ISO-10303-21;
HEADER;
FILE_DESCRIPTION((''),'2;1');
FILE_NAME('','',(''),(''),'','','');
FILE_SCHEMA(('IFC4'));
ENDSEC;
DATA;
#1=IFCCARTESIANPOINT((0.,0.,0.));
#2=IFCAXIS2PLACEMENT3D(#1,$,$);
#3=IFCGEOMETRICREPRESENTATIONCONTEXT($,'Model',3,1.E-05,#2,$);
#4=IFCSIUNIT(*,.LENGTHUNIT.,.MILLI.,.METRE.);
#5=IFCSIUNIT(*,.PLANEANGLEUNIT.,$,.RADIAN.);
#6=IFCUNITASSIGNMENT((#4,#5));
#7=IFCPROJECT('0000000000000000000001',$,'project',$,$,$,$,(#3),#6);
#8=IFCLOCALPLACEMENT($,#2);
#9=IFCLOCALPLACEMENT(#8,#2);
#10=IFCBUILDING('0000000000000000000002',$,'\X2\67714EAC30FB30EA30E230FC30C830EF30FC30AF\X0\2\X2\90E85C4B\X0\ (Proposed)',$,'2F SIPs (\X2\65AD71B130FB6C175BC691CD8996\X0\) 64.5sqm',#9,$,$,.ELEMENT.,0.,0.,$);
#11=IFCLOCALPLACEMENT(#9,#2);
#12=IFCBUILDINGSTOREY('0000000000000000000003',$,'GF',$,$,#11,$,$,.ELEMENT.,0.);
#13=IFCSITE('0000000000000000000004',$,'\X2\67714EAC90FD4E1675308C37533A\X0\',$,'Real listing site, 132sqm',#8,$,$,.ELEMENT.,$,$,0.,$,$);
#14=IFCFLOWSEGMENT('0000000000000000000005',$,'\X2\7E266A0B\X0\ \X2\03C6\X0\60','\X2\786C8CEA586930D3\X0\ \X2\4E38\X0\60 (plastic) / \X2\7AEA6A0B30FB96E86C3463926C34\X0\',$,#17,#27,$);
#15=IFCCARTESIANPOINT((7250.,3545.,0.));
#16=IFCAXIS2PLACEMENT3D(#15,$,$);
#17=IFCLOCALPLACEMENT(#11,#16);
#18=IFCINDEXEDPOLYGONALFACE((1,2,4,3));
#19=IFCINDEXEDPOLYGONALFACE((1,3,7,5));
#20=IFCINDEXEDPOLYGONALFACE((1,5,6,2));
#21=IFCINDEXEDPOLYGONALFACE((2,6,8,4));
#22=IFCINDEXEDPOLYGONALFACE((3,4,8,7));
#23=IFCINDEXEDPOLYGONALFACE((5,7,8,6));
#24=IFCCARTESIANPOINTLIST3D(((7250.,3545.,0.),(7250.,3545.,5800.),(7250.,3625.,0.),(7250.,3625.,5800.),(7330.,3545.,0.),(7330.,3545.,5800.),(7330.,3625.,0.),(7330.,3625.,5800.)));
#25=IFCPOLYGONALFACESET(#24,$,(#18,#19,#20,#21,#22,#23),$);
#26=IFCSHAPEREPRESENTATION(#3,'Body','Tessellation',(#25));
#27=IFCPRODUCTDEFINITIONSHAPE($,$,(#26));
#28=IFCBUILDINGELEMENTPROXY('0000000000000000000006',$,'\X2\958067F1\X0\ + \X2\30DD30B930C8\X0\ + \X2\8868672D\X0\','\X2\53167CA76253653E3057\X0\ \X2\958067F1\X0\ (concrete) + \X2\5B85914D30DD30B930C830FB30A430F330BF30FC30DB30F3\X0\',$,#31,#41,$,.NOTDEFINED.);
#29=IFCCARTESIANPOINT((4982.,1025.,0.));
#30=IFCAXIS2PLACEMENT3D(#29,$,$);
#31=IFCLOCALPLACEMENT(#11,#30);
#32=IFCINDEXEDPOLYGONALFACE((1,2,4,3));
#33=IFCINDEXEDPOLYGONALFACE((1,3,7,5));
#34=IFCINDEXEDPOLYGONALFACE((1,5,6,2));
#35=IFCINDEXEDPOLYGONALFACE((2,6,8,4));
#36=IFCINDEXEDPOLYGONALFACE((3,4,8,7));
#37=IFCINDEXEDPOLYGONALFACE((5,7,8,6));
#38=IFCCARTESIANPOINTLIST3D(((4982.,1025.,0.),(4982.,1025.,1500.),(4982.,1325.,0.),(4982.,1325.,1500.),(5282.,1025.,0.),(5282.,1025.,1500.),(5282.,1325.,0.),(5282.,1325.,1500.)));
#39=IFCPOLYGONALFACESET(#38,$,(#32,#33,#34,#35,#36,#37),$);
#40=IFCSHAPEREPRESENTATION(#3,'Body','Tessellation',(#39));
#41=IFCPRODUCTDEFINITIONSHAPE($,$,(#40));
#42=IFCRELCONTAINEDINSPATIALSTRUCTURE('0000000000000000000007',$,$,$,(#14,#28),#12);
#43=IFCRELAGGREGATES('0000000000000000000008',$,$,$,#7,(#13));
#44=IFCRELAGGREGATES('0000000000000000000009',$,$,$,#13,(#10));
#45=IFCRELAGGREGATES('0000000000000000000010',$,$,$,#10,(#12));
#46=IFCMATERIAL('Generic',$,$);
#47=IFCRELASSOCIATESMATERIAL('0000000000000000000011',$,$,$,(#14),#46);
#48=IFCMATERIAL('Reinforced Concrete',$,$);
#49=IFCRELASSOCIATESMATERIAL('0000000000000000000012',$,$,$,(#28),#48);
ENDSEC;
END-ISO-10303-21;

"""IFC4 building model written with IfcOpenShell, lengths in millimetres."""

from ifc_helpers import new_model, si_unit, frame, frame_2d, origin, place, context, project, spatial, rectangle, extrude, material, element, save


model = new_model("IFC4")

# Units and contexts
model_context = context("Model", 3, precision=1e-05, world=origin())
ifc_project = project(units=[si_unit("LENGTHUNIT", "METRE", prefix="MILLI"), si_unit("PLANEANGLEUNIT", "RADIAN")], contexts=[model_context])

# Site, building, storey
site_placement = place(None, origin())
site = spatial("IfcSite", under=ifc_project, at=site_placement, Name="東京都世田谷区", ObjectType="Real listing site, 132sqm", CompositionType="ELEMENT", RefElevation=0.0)
building_placement = place(site_placement, origin())
building = spatial("IfcBuilding", under=site, at=building_placement, Name="東京・リモートワーク2部屋 (Proposed)", ObjectType="2F SIPs (断熱・気密重視) 64.5sqm", CompositionType="ELEMENT", ElevationOfRefHeight=0.0, ElevationOfTerrain=0.0)
storey_placement = place(building_placement, origin())
storey = spatial("IfcBuildingStorey", under=building, at=storey_placement, Name="GF", CompositionType="ELEMENT", Elevation=0.0)

# Shared definitions
ifc_material_1 = material(Name="Reinforced Concrete")

# Flow segment
ifc_material_2 = material(Name="Generic")
flow_segment_1_placement = place(storey_placement, frame((7250.0, 3545.0, 0.0)))
element("IfcFlowSegment", 1, at=flow_segment_1_placement, inside=storey, material=ifc_material_2, Name="縦樋 φ60", Description="硬質塩ビ 丸60 (plastic) / 竪樋・雨水排水", context=model_context, shape_type="SweptSolid", body=[
    extrude(rectangle(XDim=80.0, YDim=80.0, at=frame_2d((40.0, 40.0))), frame((7250.0, 3545.0, 0.0)), (0.0, 0.0, 1.0), 5800.0),
])

# Building element proxy
proxy_placement = place(storey_placement, frame((4982.0, 1025.0, 0.0)))
element("IfcBuildingElementProxy", 2, at=proxy_placement, inside=storey, material=ifc_material_1, Name="門柱 + ポスト + 表札", Description="化粧打放し 門柱 (concrete) + 宅配ポスト・インターホン", PredefinedType="NOTDEFINED", context=model_context, shape_type="SweptSolid", body=[
    extrude(rectangle(XDim=300.0, YDim=300.0, at=frame_2d((150.0, 150.0))), frame((4982.0, 1025.0, 0.0)), (0.0, 0.0, 1.0), 1500.0),
])

save(model, "model.ifc")
